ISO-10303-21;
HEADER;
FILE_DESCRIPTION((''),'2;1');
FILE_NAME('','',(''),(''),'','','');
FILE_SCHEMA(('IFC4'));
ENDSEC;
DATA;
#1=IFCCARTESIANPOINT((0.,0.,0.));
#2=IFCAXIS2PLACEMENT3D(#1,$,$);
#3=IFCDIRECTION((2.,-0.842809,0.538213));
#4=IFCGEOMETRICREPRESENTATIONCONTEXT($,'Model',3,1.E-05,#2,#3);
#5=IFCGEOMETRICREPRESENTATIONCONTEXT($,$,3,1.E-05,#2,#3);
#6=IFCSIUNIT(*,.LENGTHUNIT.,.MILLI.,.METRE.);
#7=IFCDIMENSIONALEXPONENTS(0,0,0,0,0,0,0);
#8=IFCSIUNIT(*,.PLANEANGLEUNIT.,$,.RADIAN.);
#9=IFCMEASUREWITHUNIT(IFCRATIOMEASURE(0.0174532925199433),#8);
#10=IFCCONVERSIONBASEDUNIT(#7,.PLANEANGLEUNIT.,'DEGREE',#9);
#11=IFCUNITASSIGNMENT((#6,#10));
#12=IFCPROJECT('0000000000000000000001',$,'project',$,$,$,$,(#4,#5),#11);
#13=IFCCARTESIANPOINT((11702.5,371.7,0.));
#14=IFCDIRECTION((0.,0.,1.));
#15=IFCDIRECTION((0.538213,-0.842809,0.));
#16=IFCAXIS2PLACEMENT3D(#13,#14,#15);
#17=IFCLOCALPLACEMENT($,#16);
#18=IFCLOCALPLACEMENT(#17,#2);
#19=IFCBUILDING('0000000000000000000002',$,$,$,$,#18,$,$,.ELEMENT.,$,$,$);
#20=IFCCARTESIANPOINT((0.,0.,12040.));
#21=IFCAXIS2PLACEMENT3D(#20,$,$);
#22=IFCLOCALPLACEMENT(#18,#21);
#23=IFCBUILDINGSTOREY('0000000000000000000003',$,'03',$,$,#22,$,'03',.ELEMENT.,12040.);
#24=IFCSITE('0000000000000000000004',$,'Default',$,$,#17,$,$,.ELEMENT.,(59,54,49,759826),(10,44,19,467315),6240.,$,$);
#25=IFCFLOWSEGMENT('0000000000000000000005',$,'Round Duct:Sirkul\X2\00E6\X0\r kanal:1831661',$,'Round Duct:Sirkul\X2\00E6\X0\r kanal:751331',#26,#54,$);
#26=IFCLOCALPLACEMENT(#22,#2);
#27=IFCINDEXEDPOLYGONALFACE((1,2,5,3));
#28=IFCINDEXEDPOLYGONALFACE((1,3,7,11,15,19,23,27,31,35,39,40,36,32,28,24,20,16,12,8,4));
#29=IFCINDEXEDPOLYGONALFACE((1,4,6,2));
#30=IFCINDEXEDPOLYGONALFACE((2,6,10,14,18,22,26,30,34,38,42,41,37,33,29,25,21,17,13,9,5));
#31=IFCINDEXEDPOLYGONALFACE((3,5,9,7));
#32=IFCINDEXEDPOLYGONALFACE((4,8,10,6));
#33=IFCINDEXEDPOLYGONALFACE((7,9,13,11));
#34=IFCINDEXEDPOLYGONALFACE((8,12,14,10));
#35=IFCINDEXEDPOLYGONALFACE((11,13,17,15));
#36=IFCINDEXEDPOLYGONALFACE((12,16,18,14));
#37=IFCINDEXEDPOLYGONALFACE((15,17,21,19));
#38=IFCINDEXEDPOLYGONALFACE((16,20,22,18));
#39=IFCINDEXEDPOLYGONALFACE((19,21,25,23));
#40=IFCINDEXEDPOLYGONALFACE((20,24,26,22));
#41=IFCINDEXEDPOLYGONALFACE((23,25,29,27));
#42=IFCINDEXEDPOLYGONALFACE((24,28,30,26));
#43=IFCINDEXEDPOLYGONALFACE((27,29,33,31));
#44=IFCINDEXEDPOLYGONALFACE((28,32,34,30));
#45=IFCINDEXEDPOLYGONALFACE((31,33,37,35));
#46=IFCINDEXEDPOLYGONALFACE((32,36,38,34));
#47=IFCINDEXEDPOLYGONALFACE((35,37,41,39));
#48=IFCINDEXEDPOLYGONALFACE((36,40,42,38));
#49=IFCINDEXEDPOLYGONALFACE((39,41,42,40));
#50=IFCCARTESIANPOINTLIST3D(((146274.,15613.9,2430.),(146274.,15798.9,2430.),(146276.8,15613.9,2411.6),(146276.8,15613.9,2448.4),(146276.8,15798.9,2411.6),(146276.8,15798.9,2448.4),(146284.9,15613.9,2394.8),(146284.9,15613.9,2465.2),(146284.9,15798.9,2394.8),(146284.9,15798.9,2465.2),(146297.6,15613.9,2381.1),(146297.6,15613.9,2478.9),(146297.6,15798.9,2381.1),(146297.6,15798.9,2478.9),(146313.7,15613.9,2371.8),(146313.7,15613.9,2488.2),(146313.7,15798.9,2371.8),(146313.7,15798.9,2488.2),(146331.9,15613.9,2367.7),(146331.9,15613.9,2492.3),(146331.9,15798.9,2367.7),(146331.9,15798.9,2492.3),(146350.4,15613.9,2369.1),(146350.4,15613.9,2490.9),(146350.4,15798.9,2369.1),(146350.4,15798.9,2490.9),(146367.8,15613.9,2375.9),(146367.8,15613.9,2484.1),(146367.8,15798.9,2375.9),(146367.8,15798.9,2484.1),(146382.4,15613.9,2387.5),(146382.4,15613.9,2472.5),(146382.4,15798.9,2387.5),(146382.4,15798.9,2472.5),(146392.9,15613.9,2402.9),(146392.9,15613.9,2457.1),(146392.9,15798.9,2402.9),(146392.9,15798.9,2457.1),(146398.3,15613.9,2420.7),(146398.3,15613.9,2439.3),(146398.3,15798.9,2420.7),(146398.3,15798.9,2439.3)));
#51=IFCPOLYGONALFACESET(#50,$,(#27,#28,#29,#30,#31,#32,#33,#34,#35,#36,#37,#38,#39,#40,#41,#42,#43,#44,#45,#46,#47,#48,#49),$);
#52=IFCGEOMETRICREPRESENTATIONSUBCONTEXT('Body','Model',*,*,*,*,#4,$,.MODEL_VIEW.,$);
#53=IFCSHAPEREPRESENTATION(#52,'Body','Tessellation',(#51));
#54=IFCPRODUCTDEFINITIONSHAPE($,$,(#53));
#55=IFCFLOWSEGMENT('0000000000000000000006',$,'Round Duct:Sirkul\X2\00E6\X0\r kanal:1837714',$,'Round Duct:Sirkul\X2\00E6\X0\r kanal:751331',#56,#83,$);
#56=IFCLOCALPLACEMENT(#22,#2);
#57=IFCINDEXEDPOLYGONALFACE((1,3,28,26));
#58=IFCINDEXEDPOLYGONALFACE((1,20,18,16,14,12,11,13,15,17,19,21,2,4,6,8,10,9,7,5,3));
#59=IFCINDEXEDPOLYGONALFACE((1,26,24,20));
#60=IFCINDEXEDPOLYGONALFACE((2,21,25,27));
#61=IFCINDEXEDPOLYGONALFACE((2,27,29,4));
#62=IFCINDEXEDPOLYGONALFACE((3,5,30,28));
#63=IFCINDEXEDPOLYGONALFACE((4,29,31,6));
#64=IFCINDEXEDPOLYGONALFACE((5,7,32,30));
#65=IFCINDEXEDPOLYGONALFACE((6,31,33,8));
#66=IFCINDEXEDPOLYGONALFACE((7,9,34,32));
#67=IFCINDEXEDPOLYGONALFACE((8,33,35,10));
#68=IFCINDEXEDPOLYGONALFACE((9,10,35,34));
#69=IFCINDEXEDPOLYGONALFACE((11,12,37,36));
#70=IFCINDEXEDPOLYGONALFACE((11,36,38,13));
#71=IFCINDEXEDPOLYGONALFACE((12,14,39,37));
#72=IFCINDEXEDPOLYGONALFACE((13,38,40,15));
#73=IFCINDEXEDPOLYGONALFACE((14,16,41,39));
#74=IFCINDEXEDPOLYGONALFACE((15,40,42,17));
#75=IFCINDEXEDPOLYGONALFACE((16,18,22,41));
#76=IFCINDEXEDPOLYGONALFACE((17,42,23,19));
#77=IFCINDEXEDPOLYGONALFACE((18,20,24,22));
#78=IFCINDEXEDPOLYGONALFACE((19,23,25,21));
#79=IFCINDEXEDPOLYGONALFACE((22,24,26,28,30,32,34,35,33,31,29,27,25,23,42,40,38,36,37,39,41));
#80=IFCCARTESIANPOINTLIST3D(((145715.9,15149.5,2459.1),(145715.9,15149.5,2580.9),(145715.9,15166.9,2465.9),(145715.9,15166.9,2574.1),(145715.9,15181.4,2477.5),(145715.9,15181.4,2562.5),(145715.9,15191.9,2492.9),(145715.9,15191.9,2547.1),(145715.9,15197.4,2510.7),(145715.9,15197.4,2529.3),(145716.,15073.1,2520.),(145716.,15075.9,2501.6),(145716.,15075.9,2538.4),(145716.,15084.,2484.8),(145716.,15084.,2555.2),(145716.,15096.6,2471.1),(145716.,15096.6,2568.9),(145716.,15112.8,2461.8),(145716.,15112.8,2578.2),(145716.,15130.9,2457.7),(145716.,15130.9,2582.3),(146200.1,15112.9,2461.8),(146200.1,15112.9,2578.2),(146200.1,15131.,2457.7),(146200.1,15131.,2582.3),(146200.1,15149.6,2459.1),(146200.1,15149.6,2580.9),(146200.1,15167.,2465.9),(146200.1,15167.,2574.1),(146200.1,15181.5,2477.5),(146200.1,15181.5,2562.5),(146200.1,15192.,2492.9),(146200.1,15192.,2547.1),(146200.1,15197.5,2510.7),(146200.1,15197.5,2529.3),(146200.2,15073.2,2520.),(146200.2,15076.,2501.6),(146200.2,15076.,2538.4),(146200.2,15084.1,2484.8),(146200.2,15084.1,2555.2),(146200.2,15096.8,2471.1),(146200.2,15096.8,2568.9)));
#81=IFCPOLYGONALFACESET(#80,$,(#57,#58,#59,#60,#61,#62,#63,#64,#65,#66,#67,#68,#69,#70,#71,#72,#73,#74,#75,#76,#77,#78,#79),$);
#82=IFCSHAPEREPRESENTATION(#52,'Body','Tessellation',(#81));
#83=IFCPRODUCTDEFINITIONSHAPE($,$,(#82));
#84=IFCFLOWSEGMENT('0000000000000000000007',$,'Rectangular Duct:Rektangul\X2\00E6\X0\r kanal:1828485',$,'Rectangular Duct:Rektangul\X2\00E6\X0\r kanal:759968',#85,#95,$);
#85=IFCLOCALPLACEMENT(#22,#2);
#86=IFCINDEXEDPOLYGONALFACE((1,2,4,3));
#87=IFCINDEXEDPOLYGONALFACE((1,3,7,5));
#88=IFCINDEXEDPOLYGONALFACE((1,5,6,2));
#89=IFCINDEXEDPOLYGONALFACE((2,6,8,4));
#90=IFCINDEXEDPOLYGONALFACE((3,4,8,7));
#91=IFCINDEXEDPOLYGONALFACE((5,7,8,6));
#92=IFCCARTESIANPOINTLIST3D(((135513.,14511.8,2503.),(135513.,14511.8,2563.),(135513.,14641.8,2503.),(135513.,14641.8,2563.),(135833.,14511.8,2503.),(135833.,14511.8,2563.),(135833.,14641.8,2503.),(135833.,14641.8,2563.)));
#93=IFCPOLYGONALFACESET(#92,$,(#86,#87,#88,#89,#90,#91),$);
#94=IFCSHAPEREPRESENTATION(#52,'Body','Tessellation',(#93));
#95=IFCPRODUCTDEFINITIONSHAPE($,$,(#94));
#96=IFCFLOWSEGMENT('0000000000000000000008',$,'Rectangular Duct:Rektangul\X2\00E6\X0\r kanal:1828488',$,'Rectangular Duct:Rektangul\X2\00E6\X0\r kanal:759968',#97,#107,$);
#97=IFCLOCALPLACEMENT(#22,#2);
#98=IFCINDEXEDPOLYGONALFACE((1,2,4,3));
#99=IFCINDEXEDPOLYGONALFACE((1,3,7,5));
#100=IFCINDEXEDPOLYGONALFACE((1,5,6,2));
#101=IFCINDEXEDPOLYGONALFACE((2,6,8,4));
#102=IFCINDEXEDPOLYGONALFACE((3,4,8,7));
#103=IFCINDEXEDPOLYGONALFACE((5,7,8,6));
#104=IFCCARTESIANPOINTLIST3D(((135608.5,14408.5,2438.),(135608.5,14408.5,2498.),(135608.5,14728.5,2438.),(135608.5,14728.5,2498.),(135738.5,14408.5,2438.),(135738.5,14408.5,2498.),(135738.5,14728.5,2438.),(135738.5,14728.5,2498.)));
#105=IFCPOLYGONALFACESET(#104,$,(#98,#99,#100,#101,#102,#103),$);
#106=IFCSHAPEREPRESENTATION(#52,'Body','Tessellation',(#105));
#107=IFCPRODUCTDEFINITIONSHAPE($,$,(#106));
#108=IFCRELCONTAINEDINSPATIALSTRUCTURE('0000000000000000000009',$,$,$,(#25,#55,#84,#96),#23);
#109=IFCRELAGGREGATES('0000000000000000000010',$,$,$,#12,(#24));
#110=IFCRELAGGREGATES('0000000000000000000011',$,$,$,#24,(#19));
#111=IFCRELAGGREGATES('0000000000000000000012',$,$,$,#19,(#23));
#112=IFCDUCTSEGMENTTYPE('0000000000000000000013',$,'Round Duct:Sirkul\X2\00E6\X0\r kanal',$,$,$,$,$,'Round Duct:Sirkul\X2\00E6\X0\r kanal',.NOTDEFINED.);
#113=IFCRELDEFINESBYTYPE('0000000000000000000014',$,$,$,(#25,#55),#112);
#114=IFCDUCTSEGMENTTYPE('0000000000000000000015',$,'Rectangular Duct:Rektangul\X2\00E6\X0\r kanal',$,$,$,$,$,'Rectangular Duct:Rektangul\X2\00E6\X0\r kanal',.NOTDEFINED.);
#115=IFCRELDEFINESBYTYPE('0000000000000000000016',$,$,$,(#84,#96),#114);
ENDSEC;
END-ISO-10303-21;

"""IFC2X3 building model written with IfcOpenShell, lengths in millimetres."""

from ifc_helpers import new_model, entity, si_unit, converted_unit, direction, frame, frame_2d, origin, origin_2d_with_axis, place, context, subcontext, project, spatial, rectangle, circle, extrude, type_object, element, save


model = new_model("IFC2X3")

# Units and contexts
model_context = context("Model", 3, precision=1e-05, world=origin(), true_north=direction((2.0, -0.842809, 0.538213)))
context_of_model = context(None, 3, precision=1e-05, world=origin(), true_north=direction((2.0, -0.842809, 0.538213)))
body_context = subcontext(model_context, "Body", "Model", "MODEL_VIEW")
ifc_project = project(units=[si_unit("LENGTHUNIT", "METRE", prefix="MILLI"), converted_unit("PLANEANGLEUNIT", "DEGREE", entity("IfcRatioMeasure", 0.0174532925199433), si_unit("PLANEANGLEUNIT", "RADIAN"), dimensions=[0, 0, 0, 0, 0, 0, 0])], contexts=[model_context, context_of_model])

# Site, building, storey
site_placement = place(None, frame((11702.5, 371.7, 0.0), z_axis=(0.0, 0.0, 1.0), x_axis=(0.538213, -0.842809, 0.0)))
site = spatial("IfcSite", under=ifc_project, at=site_placement, Name="Default", CompositionType="ELEMENT", RefLatitude=(59, 54, 49, 759826), RefLongitude=(10, 44, 19, 467315), RefElevation=6240.0)
building_placement = place(site_placement, origin())
building = spatial("IfcBuilding", under=site, at=building_placement, CompositionType="ELEMENT")
storey_placement = place(building_placement, frame((0.0, 0.0, 12040.0)))
storey = spatial("IfcBuildingStorey", under=building, at=storey_placement, Name="03", LongName="03", CompositionType="ELEMENT", Elevation=12040.0)

# Flow segments
duct_segment_type_1 = type_object("IfcDuctSegmentType", Name="Round Duct:Sirkulær kanal", ElementType="Round Duct:Sirkulær kanal", PredefinedType="NOTDEFINED")
flow_segment_1_placement = place(storey_placement, origin())
element("IfcFlowSegment", 1, at=flow_segment_1_placement, inside=storey, type_object=duct_segment_type_1, Name="Round Duct:Sirkulær kanal:1831661", ObjectType="Round Duct:Sirkulær kanal:751331", context=body_context, shape_type="SweptSolid", body=[
    extrude(circle(Radius=62.5, at=frame_2d((0.0, 0.0), x_axis=(1.0, 0.0))), frame((146336.5, 15613.9, 2430.0), z_axis=(0.0, 1.0, 0.0), x_axis=(-1.0, 0.0, 0.0)), (0.0, 0.0, 1.0), 185.0),
])
flow_segment_2_placement = place(storey_placement, origin())
element("IfcFlowSegment", 2, at=flow_segment_2_placement, inside=storey, type_object=duct_segment_type_1, Name="Round Duct:Sirkulær kanal:1837714", ObjectType="Round Duct:Sirkulær kanal:751331", context=body_context, shape_type="SweptSolid", body=[
    extrude(circle(Radius=62.5, at=frame_2d((0.0, 0.0), x_axis=(1.0, 0.0))), frame((145716.0, 15135.6, 2520.0), z_axis=(1.0, 0.000226, 0.0), x_axis=(0.000226, -1.0, 0.0)), (0.0, 0.0, 1.0), 484.2),
])
duct_segment_type_2 = type_object("IfcDuctSegmentType", Name="Rectangular Duct:Rektangulær kanal", ElementType="Rectangular Duct:Rektangulær kanal", PredefinedType="NOTDEFINED")
flow_segment_3_placement = place(storey_placement, origin())
element("IfcFlowSegment", 3, at=flow_segment_3_placement, inside=storey, type_object=duct_segment_type_2, Name="Rectangular Duct:Rektangulær kanal:1828485", ObjectType="Rectangular Duct:Rektangulær kanal:759968", context=body_context, shape_type="SweptSolid", body=[
    extrude(rectangle(XDim=320.0, YDim=130.0, at=origin_2d_with_axis()), frame((135673.0, 14576.8, 2503.0)), (0.0, 0.0, 1.0), 60.0),
])
flow_segment_4_placement = place(storey_placement, origin())
element("IfcFlowSegment", 4, at=flow_segment_4_placement, inside=storey, type_object=duct_segment_type_2, Name="Rectangular Duct:Rektangulær kanal:1828488", ObjectType="Rectangular Duct:Rektangulær kanal:759968", context=body_context, shape_type="SweptSolid", body=[
    extrude(rectangle(XDim=320.0, YDim=130.0, at=frame_2d((0.0, 0.0), x_axis=(1.0, 0.0))), frame((135673.5, 14568.5, 2438.0), z_axis=(0.0, 0.0, 1.0), x_axis=(0.0, 1.0, 0.0)), (0.0, 0.0, 1.0), 60.0),
])

save(model, "model.ifc")
